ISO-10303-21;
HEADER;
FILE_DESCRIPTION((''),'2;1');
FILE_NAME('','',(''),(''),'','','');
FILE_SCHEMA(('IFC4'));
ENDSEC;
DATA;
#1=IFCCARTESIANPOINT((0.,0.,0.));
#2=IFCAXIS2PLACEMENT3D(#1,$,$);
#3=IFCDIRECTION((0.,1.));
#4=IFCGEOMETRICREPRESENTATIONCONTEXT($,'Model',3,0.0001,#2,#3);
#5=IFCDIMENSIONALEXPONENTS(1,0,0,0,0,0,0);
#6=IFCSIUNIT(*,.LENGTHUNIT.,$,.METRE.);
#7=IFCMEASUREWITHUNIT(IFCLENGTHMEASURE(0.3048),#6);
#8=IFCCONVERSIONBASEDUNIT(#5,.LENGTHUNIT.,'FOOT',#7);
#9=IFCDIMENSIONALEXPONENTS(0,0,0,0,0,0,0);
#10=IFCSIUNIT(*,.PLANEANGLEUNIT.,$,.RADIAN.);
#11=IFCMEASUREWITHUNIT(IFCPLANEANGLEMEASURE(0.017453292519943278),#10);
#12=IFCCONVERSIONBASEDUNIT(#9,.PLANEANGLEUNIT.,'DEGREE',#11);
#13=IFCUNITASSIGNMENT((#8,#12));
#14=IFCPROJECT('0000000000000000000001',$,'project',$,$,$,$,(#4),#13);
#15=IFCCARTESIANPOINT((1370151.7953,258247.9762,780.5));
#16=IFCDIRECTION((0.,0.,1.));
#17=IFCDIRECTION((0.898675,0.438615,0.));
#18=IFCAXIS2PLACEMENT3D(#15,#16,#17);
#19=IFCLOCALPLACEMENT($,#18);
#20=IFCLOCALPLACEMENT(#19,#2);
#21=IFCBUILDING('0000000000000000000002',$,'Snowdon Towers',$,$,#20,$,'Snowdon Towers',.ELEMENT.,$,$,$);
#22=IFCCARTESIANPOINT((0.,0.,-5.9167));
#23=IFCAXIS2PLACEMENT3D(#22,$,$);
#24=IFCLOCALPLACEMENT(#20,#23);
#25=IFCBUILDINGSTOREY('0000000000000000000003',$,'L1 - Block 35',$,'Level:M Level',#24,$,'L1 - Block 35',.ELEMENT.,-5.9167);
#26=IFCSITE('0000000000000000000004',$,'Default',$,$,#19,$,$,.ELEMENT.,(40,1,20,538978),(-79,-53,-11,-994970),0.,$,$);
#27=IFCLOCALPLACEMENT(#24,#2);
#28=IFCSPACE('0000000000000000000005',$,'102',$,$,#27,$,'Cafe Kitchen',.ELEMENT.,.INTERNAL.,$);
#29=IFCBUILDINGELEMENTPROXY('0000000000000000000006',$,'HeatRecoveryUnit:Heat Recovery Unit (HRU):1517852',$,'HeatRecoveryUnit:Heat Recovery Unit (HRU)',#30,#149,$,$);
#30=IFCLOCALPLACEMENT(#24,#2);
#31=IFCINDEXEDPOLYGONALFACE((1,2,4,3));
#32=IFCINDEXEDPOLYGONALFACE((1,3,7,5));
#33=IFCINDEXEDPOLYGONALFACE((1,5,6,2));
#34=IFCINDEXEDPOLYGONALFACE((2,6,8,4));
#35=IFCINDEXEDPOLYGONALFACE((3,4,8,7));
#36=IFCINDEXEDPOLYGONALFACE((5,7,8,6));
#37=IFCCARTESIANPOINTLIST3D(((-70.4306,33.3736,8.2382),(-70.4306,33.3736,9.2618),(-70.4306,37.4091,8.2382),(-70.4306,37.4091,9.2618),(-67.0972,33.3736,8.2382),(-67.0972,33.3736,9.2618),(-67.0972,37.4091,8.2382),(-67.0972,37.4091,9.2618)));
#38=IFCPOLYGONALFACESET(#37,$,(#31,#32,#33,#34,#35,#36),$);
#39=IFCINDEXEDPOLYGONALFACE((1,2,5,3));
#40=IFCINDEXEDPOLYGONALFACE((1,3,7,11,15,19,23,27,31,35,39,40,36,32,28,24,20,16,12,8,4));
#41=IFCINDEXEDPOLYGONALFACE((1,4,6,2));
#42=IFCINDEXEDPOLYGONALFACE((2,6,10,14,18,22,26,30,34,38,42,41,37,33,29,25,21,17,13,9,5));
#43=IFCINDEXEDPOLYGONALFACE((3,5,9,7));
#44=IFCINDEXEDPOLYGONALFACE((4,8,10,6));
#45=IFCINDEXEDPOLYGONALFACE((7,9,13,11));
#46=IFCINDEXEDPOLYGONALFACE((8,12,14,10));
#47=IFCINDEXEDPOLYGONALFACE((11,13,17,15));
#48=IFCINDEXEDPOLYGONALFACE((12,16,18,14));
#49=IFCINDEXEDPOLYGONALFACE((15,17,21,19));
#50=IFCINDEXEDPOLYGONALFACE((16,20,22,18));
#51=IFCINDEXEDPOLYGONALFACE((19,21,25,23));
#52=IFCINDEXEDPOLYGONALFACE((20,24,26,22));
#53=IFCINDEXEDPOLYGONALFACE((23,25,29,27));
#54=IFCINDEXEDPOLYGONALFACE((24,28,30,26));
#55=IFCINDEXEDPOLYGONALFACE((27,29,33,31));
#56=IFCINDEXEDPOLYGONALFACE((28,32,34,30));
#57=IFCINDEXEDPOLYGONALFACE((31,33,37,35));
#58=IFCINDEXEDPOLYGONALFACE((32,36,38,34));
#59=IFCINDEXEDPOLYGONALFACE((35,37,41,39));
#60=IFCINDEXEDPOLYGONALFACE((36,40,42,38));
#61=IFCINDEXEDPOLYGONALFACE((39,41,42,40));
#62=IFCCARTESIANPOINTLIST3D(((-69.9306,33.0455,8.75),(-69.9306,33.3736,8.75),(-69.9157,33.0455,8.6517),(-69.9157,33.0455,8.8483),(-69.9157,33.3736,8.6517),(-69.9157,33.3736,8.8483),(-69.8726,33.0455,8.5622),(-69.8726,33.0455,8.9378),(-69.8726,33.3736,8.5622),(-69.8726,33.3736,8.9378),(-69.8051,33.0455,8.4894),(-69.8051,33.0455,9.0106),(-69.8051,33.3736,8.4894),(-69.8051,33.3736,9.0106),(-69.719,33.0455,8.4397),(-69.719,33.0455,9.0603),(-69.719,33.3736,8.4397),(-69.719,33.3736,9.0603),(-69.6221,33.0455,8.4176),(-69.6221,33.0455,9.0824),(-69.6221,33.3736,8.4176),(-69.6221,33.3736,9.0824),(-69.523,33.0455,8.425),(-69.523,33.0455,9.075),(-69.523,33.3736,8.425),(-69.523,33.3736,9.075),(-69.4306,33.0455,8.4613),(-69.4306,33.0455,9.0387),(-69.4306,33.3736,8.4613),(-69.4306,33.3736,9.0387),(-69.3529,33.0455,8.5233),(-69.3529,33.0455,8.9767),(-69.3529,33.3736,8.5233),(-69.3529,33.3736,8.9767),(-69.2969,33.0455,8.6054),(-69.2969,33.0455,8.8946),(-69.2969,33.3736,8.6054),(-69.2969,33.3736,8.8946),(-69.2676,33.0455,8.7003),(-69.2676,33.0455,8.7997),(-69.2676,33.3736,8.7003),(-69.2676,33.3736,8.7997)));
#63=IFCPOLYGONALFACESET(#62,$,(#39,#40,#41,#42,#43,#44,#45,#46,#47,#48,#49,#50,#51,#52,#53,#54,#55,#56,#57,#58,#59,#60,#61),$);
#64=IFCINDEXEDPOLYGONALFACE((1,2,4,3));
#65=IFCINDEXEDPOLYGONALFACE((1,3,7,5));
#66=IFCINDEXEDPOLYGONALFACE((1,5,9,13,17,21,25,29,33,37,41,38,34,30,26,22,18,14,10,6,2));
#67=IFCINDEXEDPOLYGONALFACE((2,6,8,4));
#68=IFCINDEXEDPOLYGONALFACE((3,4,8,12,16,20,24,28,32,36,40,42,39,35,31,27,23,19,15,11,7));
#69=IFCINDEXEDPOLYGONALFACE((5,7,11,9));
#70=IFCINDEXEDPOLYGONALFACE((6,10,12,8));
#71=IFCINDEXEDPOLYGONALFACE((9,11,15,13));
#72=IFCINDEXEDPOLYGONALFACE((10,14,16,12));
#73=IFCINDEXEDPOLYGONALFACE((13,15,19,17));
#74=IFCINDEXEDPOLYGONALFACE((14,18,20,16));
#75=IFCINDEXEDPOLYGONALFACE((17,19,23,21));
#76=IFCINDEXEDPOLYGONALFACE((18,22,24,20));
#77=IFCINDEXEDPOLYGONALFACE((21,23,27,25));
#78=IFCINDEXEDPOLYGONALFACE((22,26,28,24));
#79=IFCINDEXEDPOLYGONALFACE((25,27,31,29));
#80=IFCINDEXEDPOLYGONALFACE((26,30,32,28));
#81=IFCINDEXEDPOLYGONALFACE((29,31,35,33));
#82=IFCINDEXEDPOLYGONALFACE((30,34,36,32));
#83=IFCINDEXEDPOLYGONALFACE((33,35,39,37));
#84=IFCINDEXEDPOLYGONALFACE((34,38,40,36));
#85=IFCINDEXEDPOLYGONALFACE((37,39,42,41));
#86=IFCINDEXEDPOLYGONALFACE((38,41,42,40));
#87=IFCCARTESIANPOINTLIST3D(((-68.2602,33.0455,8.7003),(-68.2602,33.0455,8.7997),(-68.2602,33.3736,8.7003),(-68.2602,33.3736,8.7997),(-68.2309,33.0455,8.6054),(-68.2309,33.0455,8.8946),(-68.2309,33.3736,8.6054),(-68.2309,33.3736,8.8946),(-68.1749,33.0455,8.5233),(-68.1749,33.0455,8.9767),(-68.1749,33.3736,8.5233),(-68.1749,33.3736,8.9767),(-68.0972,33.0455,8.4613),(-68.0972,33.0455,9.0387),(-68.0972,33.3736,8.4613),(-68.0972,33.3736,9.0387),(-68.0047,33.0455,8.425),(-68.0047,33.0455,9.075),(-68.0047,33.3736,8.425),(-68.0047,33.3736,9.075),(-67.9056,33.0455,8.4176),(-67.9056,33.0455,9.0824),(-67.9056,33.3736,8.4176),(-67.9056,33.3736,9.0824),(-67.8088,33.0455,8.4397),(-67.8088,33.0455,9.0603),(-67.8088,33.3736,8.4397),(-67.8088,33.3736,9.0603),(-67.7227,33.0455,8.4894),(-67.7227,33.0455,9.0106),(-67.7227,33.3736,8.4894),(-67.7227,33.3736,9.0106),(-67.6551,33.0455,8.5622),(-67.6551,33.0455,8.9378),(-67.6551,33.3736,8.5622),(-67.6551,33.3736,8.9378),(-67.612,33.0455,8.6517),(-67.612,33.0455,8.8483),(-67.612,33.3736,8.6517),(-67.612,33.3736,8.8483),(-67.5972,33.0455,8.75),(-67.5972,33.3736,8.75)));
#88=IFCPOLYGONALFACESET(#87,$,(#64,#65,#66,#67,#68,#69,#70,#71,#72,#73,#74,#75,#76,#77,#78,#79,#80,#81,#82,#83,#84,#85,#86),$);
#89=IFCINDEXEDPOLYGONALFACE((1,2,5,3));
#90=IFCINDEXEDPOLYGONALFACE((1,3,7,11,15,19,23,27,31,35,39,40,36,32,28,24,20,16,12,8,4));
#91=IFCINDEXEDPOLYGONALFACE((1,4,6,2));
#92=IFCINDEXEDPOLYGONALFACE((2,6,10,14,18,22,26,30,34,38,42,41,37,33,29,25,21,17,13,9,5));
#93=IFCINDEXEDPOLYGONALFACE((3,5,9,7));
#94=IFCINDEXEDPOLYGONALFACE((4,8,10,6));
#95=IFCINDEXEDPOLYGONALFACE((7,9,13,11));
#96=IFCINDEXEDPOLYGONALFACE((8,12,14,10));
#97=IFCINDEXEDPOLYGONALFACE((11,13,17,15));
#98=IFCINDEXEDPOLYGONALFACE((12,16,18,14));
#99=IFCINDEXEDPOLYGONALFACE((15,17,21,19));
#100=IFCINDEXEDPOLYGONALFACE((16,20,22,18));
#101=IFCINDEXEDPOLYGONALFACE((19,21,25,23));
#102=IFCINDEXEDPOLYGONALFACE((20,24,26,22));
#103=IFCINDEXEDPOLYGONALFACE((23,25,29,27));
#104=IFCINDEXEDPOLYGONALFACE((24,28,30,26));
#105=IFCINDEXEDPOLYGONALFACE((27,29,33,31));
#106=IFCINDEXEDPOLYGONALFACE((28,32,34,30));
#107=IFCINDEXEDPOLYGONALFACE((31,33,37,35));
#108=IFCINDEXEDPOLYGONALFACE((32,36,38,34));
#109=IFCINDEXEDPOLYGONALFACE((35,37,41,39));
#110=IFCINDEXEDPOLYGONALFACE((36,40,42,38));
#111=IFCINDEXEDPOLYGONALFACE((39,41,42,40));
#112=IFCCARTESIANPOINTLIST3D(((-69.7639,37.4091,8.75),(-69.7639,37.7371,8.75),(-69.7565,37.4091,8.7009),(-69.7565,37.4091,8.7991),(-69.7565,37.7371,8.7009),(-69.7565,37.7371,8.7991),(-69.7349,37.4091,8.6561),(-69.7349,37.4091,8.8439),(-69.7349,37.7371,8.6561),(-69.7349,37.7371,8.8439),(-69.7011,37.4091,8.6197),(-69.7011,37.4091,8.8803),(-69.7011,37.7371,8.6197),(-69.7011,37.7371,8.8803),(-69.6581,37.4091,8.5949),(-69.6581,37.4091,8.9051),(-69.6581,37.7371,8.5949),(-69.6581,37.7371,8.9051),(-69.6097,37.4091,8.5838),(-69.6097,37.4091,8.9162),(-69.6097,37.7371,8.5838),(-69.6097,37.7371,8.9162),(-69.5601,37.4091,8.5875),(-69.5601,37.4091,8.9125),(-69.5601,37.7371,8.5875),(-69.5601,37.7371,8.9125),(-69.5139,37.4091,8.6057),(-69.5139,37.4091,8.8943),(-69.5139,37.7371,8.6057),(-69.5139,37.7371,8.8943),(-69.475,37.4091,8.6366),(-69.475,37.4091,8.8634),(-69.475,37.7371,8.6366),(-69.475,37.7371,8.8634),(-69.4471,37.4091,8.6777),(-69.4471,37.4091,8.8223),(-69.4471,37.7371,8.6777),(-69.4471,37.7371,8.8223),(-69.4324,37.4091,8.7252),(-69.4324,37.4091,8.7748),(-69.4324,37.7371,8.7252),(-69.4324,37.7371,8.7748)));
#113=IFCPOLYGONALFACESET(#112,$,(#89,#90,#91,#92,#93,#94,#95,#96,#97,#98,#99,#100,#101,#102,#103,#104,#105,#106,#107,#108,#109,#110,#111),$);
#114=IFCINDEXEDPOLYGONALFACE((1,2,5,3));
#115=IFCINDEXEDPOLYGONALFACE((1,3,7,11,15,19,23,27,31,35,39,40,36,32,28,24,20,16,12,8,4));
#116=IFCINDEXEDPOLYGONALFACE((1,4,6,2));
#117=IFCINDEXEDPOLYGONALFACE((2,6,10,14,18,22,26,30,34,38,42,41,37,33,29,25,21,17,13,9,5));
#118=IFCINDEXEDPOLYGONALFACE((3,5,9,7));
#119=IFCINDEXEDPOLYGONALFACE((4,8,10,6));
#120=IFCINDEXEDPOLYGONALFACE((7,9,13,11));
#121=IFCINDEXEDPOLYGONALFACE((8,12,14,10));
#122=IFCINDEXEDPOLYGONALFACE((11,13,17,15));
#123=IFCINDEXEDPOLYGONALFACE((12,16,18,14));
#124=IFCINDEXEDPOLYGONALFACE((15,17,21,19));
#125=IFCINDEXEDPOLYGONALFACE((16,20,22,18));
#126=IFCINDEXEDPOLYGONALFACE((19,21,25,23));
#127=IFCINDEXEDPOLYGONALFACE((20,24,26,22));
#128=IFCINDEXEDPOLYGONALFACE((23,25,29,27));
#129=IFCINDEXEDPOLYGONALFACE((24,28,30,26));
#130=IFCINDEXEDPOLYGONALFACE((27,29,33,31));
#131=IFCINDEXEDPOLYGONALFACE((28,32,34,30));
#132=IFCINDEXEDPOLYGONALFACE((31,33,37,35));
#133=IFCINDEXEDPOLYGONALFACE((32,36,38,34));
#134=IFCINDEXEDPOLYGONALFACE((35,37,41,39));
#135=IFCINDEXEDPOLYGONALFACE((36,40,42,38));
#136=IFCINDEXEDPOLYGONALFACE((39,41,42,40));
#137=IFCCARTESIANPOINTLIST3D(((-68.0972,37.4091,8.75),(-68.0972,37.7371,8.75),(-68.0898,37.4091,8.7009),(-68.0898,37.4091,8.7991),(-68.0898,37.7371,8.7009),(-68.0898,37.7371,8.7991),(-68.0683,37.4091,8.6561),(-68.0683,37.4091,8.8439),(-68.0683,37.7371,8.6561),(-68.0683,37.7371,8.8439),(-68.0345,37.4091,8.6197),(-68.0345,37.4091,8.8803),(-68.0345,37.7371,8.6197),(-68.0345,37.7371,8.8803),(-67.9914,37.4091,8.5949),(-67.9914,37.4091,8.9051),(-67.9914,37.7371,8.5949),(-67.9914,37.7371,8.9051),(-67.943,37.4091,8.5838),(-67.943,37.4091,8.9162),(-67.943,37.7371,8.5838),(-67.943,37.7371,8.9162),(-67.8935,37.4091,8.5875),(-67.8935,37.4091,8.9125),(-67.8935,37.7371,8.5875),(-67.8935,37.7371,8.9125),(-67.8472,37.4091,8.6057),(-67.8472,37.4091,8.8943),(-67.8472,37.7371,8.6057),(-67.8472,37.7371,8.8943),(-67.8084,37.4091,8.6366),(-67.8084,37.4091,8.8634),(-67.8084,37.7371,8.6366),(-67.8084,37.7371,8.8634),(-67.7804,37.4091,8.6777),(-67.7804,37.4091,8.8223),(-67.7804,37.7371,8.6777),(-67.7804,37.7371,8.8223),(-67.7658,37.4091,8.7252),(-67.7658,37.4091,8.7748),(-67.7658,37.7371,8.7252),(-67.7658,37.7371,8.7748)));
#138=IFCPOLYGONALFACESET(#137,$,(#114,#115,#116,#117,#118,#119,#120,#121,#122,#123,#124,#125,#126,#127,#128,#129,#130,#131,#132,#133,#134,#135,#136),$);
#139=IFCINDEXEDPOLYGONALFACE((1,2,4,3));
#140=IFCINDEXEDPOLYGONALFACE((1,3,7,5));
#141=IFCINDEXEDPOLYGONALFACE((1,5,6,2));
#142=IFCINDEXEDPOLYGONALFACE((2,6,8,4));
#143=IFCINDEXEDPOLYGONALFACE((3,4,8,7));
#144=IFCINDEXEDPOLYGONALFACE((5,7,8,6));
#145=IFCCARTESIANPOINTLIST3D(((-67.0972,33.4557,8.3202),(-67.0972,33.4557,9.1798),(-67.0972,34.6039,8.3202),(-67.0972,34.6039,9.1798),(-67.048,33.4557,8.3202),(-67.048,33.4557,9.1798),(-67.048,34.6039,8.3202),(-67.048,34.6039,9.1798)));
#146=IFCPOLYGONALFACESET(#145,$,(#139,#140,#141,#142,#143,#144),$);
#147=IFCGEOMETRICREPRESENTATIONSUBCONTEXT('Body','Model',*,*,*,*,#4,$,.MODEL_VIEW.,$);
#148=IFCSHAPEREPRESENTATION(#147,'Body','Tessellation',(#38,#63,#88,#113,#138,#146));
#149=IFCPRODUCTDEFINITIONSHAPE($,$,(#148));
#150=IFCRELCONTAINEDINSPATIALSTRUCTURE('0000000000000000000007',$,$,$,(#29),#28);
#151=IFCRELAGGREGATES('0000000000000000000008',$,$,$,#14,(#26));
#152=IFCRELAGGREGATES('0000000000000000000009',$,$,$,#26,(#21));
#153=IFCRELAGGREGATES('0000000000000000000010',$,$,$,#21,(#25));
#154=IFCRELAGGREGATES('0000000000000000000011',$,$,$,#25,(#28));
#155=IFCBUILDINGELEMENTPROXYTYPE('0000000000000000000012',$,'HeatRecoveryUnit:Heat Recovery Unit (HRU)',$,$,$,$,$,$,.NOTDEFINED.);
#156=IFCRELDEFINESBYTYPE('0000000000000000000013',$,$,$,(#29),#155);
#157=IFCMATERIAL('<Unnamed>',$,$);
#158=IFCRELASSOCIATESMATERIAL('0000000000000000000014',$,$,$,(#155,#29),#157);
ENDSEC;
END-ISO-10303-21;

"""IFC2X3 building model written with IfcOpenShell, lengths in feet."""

from ifc_helpers import new_model, entity, si_unit, converted_unit, direction, frame, frame_2d, origin, origin_2d_with_axis, place, context, subcontext, project, spatial, rectangle, circle, extrude, source, transform, mapped, material, type_object, type_shapes, element, save


model = new_model("IFC2X3")

# Units and contexts
model_context = context("Model", 3, precision=0.0001, world=origin(), true_north=direction((0.0, 1.0)))
body_context = subcontext(model_context, "Body", "Model", "MODEL_VIEW")
ifc_project = project(units=[converted_unit("LENGTHUNIT", "FOOT", entity("IfcLengthMeasure", 0.3048), si_unit("LENGTHUNIT", "METRE"), dimensions=[1, 0, 0, 0, 0, 0, 0]), converted_unit("PLANEANGLEUNIT", "DEGREE", entity("IfcPlaneAngleMeasure", 0.017453292519943278), si_unit("PLANEANGLEUNIT", "RADIAN"), dimensions=[0, 0, 0, 0, 0, 0, 0])], contexts=[model_context])

# Site, building, storey
site_placement = place(None, frame((1370151.7953, 258247.9762, 780.5), z_axis=(0.0, 0.0, 1.0), x_axis=(0.898675, 0.438615, 0.0)))
site = spatial("IfcSite", under=ifc_project, at=site_placement, Name="Default", CompositionType="ELEMENT", RefLatitude=(40, 1, 20, 538978), RefLongitude=(-79, -53, -11, -994970), RefElevation=0.0)
building_placement = place(site_placement, origin())
building = spatial("IfcBuilding", under=site, at=building_placement, Name="Snowdon Towers", LongName="Snowdon Towers", CompositionType="ELEMENT")
storey_placement = place(building_placement, frame((0.0, 0.0, -5.9167)))
storey = spatial("IfcBuildingStorey", under=building, at=storey_placement, Name="L1 - Block 35", ObjectType="Level:M Level", LongName="L1 - Block 35", CompositionType="ELEMENT", Elevation=-5.9167)

# Shared definitions
ifc_material = material(Name="<Unnamed>")

# Shared definitions
space_1_placement = place(storey_placement, origin())
space_1 = spatial("IfcSpace", under=storey, at=space_1_placement, Name="102", LongName="Cafe Kitchen", CompositionType="ELEMENT", InteriorOrExteriorSpace="INTERNAL")

# Building element proxy
building_element_proxy_type = type_object("IfcBuildingElementProxyType", Name="HeatRecoveryUnit:Heat Recovery Unit (HRU)", PredefinedType="NOTDEFINED", material=ifc_material)
shared_shape_1 = source(origin(), body_context, "Body", "SweptSolid", [
    extrude(rectangle(XDim=3.3333, YDim=4.0354, at=origin_2d_with_axis()), frame((0.0, 0.0, 0.0), z_axis=(0.0, 0.0, 1.0), x_axis=(-1.0, 0.0, 0.0)), (0.0, 0.0, 1.0), 1.0236),
    extrude(circle(Radius=0.3333, at=frame_2d((0.0, 0.0), x_axis=(1.0, 0.0))), frame((-0.8333, -2.3458, 0.5118), z_axis=(0.0, 1.0, 0.0), x_axis=(-1.0, 0.0, 0.0)), (0.0, 0.0, 1.0), 0.3281),
    extrude(circle(Radius=0.3333, at=frame_2d((0.0, 0.0), x_axis=(1.0, 0.0))), frame((0.8333, -2.3458, 0.5118), z_axis=(0.0, 1.0, 0.0), x_axis=(1.0, 0.0, 0.0)), (0.0, 0.0, 1.0), 0.3281),
    extrude(circle(Radius=0.1667, at=frame_2d((0.0, 0.0), x_axis=(1.0, 0.0))), frame((-0.8333, 2.0177, 0.5118), z_axis=(0.0, 1.0, 0.0), x_axis=(-1.0, 0.0, 0.0)), (0.0, 0.0, 1.0), 0.3281),
    extrude(circle(Radius=0.1667, at=frame_2d((0.0, 0.0), x_axis=(1.0, 0.0))), frame((0.8333, 2.0177, 0.5118), z_axis=(0.0, 1.0, 0.0), x_axis=(-1.0, 0.0, 0.0)), (0.0, 0.0, 1.0), 0.3281),
    extrude(rectangle(XDim=0.0492, YDim=1.1483, at=origin_2d_with_axis()), frame((1.6913, -1.3615, 0.082), z_axis=(0.0, 0.0, 1.0), x_axis=(-1.0, 0.0, 0.0)), (0.0, 0.0, 1.0), 0.8596),
])
type_shapes(building_element_proxy_type, [shared_shape_1])
proxy_1_placement = place(space_1_placement, frame((-68.7639, 35.3913, 8.2382)))
element("IfcBuildingElementProxy", 1, at=proxy_1_placement, inside=space_1, type_object=building_element_proxy_type, material=ifc_material, Name="HeatRecoveryUnit:Heat Recovery Unit (HRU):1517852", ObjectType="HeatRecoveryUnit:Heat Recovery Unit (HRU)", context=body_context, shape_type="MappedRepresentation", body=[
    mapped(shared_shape_1, transform((0.0, 0.0, 0.0), scale=1.0)),
])

save(model, "model.ifc")
